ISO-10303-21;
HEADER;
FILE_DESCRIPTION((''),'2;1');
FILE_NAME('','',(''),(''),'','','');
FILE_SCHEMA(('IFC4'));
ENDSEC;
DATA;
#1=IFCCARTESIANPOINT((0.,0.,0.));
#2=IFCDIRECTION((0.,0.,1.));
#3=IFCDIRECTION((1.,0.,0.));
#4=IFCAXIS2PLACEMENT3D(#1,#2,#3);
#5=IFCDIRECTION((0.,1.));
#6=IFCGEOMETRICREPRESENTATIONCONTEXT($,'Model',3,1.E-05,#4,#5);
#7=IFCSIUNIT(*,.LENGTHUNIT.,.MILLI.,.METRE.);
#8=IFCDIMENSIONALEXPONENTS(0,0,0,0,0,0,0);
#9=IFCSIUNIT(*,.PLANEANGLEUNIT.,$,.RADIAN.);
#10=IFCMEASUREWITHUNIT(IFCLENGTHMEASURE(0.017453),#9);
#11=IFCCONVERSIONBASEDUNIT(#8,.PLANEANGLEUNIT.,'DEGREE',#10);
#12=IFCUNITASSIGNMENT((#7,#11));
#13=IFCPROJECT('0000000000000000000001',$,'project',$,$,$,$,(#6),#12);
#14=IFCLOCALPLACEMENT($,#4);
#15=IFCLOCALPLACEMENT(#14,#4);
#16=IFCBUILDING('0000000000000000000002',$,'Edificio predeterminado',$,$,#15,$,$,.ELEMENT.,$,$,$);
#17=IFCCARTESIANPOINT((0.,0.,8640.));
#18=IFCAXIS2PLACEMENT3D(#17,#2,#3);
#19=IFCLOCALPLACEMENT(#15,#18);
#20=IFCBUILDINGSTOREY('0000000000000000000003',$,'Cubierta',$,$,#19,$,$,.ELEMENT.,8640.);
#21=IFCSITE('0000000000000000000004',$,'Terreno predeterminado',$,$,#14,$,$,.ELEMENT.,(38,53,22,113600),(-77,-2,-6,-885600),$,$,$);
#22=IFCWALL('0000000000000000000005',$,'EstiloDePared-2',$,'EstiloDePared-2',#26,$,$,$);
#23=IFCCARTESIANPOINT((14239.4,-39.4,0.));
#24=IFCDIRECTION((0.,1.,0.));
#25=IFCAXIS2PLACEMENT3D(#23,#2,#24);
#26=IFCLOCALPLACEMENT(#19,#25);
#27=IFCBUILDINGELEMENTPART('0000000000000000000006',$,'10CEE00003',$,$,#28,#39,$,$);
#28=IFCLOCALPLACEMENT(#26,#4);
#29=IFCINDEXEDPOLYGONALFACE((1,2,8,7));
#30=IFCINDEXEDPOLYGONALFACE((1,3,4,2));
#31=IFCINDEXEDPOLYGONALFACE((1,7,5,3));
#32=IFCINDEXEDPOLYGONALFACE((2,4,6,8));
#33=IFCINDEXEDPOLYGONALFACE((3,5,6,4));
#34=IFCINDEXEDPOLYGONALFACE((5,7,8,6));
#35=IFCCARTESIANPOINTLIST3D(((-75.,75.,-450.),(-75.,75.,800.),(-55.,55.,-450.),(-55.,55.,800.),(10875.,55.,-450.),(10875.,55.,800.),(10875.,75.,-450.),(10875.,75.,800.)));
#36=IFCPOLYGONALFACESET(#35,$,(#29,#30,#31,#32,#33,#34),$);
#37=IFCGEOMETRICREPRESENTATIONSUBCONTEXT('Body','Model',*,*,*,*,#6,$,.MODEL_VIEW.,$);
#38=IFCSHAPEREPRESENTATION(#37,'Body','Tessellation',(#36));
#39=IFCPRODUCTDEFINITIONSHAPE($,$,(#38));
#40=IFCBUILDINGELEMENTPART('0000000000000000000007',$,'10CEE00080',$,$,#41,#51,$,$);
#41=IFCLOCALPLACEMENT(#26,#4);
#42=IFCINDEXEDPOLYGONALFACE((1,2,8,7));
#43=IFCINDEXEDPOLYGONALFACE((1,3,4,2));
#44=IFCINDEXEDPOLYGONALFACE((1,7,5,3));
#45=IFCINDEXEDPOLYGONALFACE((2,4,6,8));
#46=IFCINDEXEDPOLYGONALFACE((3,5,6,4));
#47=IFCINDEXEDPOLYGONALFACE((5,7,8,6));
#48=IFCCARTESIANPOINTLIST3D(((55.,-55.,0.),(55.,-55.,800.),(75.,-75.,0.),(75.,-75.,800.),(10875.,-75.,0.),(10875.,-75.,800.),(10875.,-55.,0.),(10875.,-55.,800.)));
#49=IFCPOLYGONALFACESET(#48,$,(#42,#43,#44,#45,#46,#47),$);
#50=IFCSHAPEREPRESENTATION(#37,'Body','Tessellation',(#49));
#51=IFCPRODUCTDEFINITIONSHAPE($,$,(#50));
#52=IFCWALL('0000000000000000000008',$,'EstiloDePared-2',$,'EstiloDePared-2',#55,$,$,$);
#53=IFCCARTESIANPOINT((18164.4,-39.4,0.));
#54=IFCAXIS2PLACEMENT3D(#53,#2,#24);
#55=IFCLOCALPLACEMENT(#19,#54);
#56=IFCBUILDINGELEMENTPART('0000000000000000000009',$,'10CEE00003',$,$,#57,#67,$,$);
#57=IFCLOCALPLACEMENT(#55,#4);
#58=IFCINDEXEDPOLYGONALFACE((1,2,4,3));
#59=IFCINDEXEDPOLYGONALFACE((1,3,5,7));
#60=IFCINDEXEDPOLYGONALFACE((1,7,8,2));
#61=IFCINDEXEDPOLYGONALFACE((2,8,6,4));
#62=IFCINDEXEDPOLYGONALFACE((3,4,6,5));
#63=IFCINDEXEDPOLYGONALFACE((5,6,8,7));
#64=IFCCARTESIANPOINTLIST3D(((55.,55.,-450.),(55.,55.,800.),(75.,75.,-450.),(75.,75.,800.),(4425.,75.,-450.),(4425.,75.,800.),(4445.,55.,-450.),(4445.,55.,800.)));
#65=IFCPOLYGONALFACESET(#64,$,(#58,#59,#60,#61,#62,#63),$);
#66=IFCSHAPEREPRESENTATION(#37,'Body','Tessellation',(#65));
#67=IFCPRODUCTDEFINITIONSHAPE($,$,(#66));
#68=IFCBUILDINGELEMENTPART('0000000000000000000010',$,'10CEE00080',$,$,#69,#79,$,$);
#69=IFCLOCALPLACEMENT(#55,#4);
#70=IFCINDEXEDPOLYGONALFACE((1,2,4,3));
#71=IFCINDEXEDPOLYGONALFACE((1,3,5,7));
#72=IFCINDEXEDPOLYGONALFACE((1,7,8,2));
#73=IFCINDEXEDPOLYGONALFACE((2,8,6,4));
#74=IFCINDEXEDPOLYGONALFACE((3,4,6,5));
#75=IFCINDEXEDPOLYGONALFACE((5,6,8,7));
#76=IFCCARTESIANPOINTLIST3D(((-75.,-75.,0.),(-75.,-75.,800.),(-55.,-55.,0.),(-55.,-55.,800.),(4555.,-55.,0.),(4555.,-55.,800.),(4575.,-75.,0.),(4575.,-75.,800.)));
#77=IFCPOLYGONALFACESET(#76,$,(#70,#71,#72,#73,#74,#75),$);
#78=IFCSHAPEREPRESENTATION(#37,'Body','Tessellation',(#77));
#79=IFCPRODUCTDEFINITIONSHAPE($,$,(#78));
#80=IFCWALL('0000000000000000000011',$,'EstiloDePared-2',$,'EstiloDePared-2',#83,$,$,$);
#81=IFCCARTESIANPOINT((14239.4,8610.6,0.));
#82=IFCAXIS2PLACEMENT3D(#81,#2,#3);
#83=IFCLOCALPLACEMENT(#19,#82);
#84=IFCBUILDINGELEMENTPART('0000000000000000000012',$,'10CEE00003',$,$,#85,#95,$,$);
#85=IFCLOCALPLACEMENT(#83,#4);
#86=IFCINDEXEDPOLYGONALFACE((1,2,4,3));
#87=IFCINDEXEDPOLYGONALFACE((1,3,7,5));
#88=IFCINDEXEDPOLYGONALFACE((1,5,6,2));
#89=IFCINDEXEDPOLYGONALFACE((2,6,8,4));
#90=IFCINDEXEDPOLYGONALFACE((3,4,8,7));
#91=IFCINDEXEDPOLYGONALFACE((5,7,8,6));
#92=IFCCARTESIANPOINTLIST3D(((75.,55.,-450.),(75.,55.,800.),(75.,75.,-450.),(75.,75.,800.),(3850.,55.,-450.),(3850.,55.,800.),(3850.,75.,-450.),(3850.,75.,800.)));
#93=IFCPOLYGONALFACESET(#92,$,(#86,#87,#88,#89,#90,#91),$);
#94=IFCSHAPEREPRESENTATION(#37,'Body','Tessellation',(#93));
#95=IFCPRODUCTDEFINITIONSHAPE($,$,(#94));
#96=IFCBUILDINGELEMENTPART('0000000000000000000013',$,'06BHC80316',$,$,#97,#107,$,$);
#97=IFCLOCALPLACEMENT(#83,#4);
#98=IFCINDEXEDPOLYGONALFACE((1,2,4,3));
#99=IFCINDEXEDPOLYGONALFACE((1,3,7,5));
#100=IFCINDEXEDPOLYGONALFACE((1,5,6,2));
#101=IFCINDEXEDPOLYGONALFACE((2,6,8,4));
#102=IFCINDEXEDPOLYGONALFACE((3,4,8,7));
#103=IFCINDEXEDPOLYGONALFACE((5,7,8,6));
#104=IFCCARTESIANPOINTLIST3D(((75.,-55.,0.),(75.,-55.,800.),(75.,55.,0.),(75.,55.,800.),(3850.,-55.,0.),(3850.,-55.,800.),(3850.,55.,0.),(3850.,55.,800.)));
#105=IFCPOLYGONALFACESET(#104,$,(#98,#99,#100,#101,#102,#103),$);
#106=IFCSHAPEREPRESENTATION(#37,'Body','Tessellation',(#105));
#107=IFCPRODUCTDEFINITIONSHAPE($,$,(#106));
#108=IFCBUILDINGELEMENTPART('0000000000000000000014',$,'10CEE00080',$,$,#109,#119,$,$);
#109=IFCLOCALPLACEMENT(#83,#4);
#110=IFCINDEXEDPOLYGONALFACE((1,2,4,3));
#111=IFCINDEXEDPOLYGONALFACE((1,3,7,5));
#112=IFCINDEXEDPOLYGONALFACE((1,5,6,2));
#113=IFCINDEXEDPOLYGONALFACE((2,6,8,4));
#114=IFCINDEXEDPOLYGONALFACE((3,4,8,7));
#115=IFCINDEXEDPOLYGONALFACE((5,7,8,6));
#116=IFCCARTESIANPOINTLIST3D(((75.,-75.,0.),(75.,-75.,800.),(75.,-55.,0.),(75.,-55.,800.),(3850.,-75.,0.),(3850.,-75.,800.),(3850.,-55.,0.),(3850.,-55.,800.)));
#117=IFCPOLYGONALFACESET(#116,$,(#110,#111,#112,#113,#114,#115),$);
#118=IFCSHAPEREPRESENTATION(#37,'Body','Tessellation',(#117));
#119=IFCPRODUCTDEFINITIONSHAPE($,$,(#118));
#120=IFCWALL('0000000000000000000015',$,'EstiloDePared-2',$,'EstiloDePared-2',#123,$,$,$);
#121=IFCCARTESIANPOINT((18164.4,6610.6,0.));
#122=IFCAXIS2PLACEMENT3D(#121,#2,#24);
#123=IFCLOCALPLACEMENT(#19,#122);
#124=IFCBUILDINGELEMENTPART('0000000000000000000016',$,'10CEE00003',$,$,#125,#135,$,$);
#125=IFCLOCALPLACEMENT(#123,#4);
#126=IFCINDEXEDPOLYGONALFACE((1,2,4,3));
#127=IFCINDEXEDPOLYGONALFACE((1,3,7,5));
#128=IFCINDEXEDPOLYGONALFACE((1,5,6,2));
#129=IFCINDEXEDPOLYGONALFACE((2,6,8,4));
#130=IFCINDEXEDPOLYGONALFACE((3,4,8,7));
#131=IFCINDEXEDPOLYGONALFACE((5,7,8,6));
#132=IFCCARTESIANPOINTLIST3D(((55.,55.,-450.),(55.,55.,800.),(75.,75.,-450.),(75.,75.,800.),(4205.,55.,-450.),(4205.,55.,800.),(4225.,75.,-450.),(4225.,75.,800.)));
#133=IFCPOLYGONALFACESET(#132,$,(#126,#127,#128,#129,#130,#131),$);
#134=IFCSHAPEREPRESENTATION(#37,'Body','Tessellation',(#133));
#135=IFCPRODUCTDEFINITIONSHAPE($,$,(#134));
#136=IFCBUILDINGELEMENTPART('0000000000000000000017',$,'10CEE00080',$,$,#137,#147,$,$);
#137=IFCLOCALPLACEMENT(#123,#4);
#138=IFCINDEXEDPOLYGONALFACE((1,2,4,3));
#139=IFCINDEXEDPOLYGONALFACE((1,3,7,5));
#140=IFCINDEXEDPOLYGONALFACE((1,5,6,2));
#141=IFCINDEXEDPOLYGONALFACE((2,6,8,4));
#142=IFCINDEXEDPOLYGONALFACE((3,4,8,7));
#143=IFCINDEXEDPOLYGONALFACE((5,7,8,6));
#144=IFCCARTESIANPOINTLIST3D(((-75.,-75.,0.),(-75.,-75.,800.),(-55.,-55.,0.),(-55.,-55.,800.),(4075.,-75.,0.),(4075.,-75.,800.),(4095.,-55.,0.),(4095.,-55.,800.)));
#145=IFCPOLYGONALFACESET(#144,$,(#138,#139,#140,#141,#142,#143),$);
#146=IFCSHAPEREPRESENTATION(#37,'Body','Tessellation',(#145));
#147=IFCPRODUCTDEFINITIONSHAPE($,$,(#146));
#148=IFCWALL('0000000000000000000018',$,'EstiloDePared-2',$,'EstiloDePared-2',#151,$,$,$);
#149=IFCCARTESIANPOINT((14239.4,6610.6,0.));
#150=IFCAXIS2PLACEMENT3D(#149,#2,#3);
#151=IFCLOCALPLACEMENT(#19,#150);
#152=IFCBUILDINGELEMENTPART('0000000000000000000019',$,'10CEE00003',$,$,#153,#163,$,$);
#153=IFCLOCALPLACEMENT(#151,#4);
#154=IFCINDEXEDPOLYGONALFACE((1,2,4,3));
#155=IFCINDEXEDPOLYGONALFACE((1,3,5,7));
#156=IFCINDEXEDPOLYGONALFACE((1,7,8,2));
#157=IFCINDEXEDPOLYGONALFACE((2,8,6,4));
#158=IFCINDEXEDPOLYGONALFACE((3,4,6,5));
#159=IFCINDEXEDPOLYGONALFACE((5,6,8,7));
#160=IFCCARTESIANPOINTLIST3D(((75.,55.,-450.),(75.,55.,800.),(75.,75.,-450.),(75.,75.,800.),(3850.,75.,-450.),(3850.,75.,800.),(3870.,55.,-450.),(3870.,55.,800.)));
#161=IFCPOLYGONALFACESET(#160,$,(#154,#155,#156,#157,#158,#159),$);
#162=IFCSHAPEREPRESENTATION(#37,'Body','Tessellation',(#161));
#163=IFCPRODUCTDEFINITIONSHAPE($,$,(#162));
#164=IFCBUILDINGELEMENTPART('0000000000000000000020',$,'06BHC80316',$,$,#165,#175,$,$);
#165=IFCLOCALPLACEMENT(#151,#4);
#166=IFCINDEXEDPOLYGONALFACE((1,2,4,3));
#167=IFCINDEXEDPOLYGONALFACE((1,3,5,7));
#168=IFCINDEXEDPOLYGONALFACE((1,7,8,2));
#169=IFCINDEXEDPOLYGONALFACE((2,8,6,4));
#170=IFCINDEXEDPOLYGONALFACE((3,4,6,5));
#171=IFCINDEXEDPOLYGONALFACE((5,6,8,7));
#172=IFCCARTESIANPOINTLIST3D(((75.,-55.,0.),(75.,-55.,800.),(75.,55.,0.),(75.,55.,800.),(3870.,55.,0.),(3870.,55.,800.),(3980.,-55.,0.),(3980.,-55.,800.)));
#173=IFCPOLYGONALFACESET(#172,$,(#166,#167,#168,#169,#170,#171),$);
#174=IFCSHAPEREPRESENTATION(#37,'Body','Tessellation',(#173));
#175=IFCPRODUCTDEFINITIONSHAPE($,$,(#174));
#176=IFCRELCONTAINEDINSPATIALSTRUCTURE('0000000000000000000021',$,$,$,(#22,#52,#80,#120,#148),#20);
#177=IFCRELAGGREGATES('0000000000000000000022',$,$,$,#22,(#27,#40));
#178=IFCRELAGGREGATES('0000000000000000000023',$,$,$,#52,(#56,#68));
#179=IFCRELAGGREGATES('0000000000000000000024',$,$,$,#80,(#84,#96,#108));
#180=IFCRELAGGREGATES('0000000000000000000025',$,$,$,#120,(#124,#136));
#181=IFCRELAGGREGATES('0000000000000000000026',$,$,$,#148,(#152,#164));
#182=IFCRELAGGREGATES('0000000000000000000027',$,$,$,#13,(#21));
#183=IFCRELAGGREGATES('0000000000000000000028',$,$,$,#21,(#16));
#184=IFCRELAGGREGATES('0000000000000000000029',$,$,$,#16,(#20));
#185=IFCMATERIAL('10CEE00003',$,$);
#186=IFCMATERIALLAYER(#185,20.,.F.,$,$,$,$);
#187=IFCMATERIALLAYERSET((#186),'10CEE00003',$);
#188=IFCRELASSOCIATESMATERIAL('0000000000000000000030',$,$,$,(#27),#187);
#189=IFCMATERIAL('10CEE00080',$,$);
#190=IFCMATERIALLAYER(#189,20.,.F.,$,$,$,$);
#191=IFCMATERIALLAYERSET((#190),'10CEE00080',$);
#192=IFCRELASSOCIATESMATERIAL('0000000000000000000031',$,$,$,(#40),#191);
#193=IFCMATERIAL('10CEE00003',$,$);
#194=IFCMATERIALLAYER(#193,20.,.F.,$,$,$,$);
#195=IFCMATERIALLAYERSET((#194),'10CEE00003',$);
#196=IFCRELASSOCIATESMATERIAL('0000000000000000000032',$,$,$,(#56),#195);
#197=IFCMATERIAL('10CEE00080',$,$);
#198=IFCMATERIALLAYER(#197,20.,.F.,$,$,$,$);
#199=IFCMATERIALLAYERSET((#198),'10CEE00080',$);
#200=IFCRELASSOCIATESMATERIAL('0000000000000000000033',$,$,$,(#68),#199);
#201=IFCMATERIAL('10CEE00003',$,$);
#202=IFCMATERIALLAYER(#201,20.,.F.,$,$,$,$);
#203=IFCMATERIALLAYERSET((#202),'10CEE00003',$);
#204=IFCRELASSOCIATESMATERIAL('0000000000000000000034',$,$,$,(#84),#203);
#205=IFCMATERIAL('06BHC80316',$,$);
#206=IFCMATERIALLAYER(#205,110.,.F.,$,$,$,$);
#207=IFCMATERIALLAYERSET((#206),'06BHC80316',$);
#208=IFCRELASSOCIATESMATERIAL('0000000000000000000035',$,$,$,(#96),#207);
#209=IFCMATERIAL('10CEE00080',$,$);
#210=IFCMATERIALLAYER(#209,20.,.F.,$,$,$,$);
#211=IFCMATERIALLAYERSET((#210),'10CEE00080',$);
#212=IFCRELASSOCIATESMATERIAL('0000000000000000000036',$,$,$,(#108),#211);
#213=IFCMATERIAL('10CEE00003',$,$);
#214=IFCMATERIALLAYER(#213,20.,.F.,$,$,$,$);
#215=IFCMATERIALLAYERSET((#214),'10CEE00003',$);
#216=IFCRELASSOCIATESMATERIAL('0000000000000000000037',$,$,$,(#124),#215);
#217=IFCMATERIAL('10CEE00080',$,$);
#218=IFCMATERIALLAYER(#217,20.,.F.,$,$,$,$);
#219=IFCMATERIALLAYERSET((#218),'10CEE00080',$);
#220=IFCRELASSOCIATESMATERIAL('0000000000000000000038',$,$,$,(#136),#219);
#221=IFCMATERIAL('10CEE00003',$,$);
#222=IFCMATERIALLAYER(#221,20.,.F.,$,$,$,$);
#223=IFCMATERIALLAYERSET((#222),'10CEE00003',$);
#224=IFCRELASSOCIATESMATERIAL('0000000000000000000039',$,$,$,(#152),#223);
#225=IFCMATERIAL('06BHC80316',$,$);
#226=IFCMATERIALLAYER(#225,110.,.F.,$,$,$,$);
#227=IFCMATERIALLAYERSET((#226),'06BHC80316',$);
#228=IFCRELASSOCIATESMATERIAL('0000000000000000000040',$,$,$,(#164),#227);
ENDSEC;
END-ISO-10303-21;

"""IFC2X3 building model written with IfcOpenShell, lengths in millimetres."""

from ifc_helpers import new_model, entity, si_unit, converted_unit, direction, frame, origin_with_axes, place, context, subcontext, project, spatial, polyline, outline, extrude, material, layer, layer_set, layer_usage, element, aggregate, save


model = new_model("IFC2X3")

# Units and contexts
model_context = context("Model", 3, precision=1e-05, world=origin_with_axes(), true_north=direction((0.0, 1.0)))
body_context = subcontext(model_context, "Body", "Model", "MODEL_VIEW")
ifc_project = project(units=[si_unit("LENGTHUNIT", "METRE", prefix="MILLI"), converted_unit("PLANEANGLEUNIT", "DEGREE", entity("IfcLengthMeasure", 0.017453), si_unit("PLANEANGLEUNIT", "RADIAN"), dimensions=[0, 0, 0, 0, 0, 0, 0])], contexts=[model_context])

# Site, building, storey
site_placement = place(None, origin_with_axes())
site = spatial("IfcSite", under=ifc_project, at=site_placement, Name="Terreno predeterminado", CompositionType="ELEMENT", RefLatitude=(38, 53, 22, 113600), RefLongitude=(-77, -2, -6, -885600))
building_placement = place(site_placement, origin_with_axes())
building = spatial("IfcBuilding", under=site, at=building_placement, Name="Edificio predeterminado", CompositionType="ELEMENT")
storey_placement = place(building_placement, frame((0.0, 0.0, 8640.0), z_axis=(0.0, 0.0, 1.0), x_axis=(1.0, 0.0, 0.0)))
storey = spatial("IfcBuildingStorey", under=building, at=storey_placement, Name="Cubierta", CompositionType="ELEMENT", Elevation=8640.0)

# Walls, building element parts
wall_1_placement = place(storey_placement, frame((14239.4, -39.4, 0.0), z_axis=(0.0, 0.0, 1.0), x_axis=(0.0, 1.0, 0.0)))
wall_1 = element("IfcWall", 1, at=wall_1_placement, inside=storey, Name="EstiloDePared-2", ObjectType="EstiloDePared-2")
ifc_material_1 = material(Name="10CEE00003")
ifc_layer_1 = layer(ifc_material_1, 20.0, ventilated=False)
ifc_layer_set_1 = layer_set([ifc_layer_1], Name="10CEE00003")
ifc_layer_usage_1 = layer_usage(ifc_layer_set_1, "AXIS2", "NEGATIVE", -75.0)
building_element_part_1_placement = place(wall_1_placement, origin_with_axes())
building_element_part_1 = element("IfcBuildingElementPart", 2, at=building_element_part_1_placement, material=ifc_layer_usage_1, Name="10CEE00003", context=body_context, shape_type="SweptSolid", body=[
    extrude(outline(polyline([(10875.0, 75.0), (10875.0, 55.0), (-55.0, 55.0), (-75.0, 75.0), (10875.0, 75.0)])), frame((0.0, 0.0, -450.0), z_axis=(0.0, 0.0, 1.0), x_axis=(1.0, 0.0, 0.0)), (0.0, 0.0, 1.0), 1250.0),
])
ifc_material_2 = material(Name="10CEE00080")
ifc_layer_2 = layer(ifc_material_2, 20.0, ventilated=False)
ifc_layer_set_2 = layer_set([ifc_layer_2], Name="10CEE00080")
ifc_layer_usage_2 = layer_usage(ifc_layer_set_2, "AXIS2", "NEGATIVE", 55.0)
building_element_part_2_placement = place(wall_1_placement, origin_with_axes())
building_element_part_2 = element("IfcBuildingElementPart", 3, at=building_element_part_2_placement, material=ifc_layer_usage_2, Name="10CEE00080", context=body_context, shape_type="SweptSolid", body=[
    extrude(outline(polyline([(10875.0, -55.0), (10875.0, -75.0), (75.0, -75.0), (55.0, -55.0), (10875.0, -55.0)])), origin_with_axes(), (0.0, 0.0, 1.0), 800.0),
])
aggregate(wall_1, [building_element_part_1, building_element_part_2])
wall_2_placement = place(storey_placement, frame((18164.4, -39.4, 0.0), z_axis=(0.0, 0.0, 1.0), x_axis=(0.0, 1.0, 0.0)))
wall_2 = element("IfcWall", 4, at=wall_2_placement, inside=storey, Name="EstiloDePared-2", ObjectType="EstiloDePared-2")
ifc_material_3 = material(Name="10CEE00003")
ifc_layer_3 = layer(ifc_material_3, 20.0, ventilated=False)
ifc_layer_set_3 = layer_set([ifc_layer_3], Name="10CEE00003")
ifc_layer_usage_3 = layer_usage(ifc_layer_set_3, "AXIS2", "NEGATIVE", -75.0)
building_element_part_3_placement = place(wall_2_placement, origin_with_axes())
building_element_part_3 = element("IfcBuildingElementPart", 5, at=building_element_part_3_placement, material=ifc_layer_usage_3, Name="10CEE00003", context=body_context, shape_type="SweptSolid", body=[
    extrude(outline(polyline([(4425.0, 75.0), (4445.0, 55.0), (55.0, 55.0), (75.0, 75.0), (4425.0, 75.0)])), frame((0.0, 0.0, -450.0), z_axis=(0.0, 0.0, 1.0), x_axis=(1.0, 0.0, 0.0)), (0.0, 0.0, 1.0), 1250.0),
])
ifc_material_4 = material(Name="10CEE00080")
ifc_layer_4 = layer(ifc_material_4, 20.0, ventilated=False)
ifc_layer_set_4 = layer_set([ifc_layer_4], Name="10CEE00080")
ifc_layer_usage_4 = layer_usage(ifc_layer_set_4, "AXIS2", "NEGATIVE", 55.0)
building_element_part_4_placement = place(wall_2_placement, origin_with_axes())
building_element_part_4 = element("IfcBuildingElementPart", 6, at=building_element_part_4_placement, material=ifc_layer_usage_4, Name="10CEE00080", context=body_context, shape_type="SweptSolid", body=[
    extrude(outline(polyline([(4555.0, -55.0), (4575.0, -75.0), (-75.0, -75.0), (-55.0, -55.0), (4555.0, -55.0)])), origin_with_axes(), (0.0, 0.0, 1.0), 800.0),
])
aggregate(wall_2, [building_element_part_3, building_element_part_4])
wall_3_placement = place(storey_placement, frame((14239.4, 8610.6, 0.0), z_axis=(0.0, 0.0, 1.0), x_axis=(1.0, 0.0, 0.0)))
wall_3 = element("IfcWall", 7, at=wall_3_placement, inside=storey, Name="EstiloDePared-2", ObjectType="EstiloDePared-2")
ifc_material_5 = material(Name="10CEE00003")
ifc_layer_5 = layer(ifc_material_5, 20.0, ventilated=False)
ifc_layer_set_5 = layer_set([ifc_layer_5], Name="10CEE00003")
ifc_layer_usage_5 = layer_usage(ifc_layer_set_5, "AXIS2", "NEGATIVE", -75.0)
building_element_part_5_placement = place(wall_3_placement, origin_with_axes())
building_element_part_5 = element("IfcBuildingElementPart", 8, at=building_element_part_5_placement, material=ifc_layer_usage_5, Name="10CEE00003", context=body_context, shape_type="SweptSolid", body=[
    extrude(outline(polyline([(3850.0, 75.0), (3850.0, 55.0), (75.0, 55.0), (75.0, 75.0), (3850.0, 75.0)])), frame((0.0, 0.0, -450.0), z_axis=(0.0, 0.0, 1.0), x_axis=(1.0, 0.0, 0.0)), (0.0, 0.0, 1.0), 1250.0),
])
ifc_material_6 = material(Name="06BHC80316")
ifc_layer_6 = layer(ifc_material_6, 110.0, ventilated=False)
ifc_layer_set_6 = layer_set([ifc_layer_6], Name="06BHC80316")
ifc_layer_usage_6 = layer_usage(ifc_layer_set_6, "AXIS2", "NEGATIVE", -55.0)
building_element_part_6_placement = place(wall_3_placement, origin_with_axes())
building_element_part_6 = element("IfcBuildingElementPart", 9, at=building_element_part_6_placement, material=ifc_layer_usage_6, Name="06BHC80316", context=body_context, shape_type="SweptSolid", body=[
    extrude(outline(polyline([(3850.0, 55.0), (3850.0, -55.0), (75.0, -55.0), (75.0, 55.0), (3850.0, 55.0)])), origin_with_axes(), (0.0, 0.0, 1.0), 800.0),
])
ifc_material_7 = material(Name="10CEE00080")
ifc_layer_7 = layer(ifc_material_7, 20.0, ventilated=False)
ifc_layer_set_7 = layer_set([ifc_layer_7], Name="10CEE00080")
ifc_layer_usage_7 = layer_usage(ifc_layer_set_7, "AXIS2", "NEGATIVE", 55.0)
building_element_part_7_placement = place(wall_3_placement, origin_with_axes())
building_element_part_7 = element("IfcBuildingElementPart", 10, at=building_element_part_7_placement, material=ifc_layer_usage_7, Name="10CEE00080", context=body_context, shape_type="SweptSolid", body=[
    extrude(outline(polyline([(3850.0, -55.0), (3850.0, -75.0), (75.0, -75.0), (75.0, -55.0), (3850.0, -55.0)])), origin_with_axes(), (0.0, 0.0, 1.0), 800.0),
])
aggregate(wall_3, [building_element_part_5, building_element_part_6, building_element_part_7])
wall_4_placement = place(storey_placement, frame((18164.4, 6610.6, 0.0), z_axis=(0.0, 0.0, 1.0), x_axis=(0.0, 1.0, 0.0)))
wall_4 = element("IfcWall", 11, at=wall_4_placement, inside=storey, Name="EstiloDePared-2", ObjectType="EstiloDePared-2")
ifc_material_8 = material(Name="10CEE00003")
ifc_layer_8 = layer(ifc_material_8, 20.0, ventilated=False)
ifc_layer_set_8 = layer_set([ifc_layer_8], Name="10CEE00003")
ifc_layer_usage_8 = layer_usage(ifc_layer_set_8, "AXIS2", "NEGATIVE", -75.0)
building_element_part_8_placement = place(wall_4_placement, origin_with_axes())
building_element_part_8 = element("IfcBuildingElementPart", 12, at=building_element_part_8_placement, material=ifc_layer_usage_8, Name="10CEE00003", context=body_context, shape_type="SweptSolid", body=[
    extrude(outline(polyline([(4225.0, 75.0), (4205.0, 55.0), (55.0, 55.0), (75.0, 75.0), (4225.0, 75.0)])), frame((0.0, 0.0, -450.0), z_axis=(0.0, 0.0, 1.0), x_axis=(1.0, 0.0, 0.0)), (0.0, 0.0, 1.0), 1250.0),
])
ifc_material_9 = material(Name="10CEE00080")
ifc_layer_9 = layer(ifc_material_9, 20.0, ventilated=False)
ifc_layer_set_9 = layer_set([ifc_layer_9], Name="10CEE00080")
ifc_layer_usage_9 = layer_usage(ifc_layer_set_9, "AXIS2", "NEGATIVE", 55.0)
building_element_part_9_placement = place(wall_4_placement, origin_with_axes())
building_element_part_9 = element("IfcBuildingElementPart", 13, at=building_element_part_9_placement, material=ifc_layer_usage_9, Name="10CEE00080", context=body_context, shape_type="SweptSolid", body=[
    extrude(outline(polyline([(4095.0, -55.0), (4075.0, -75.0), (-75.0, -75.0), (-55.0, -55.0), (4095.0, -55.0)])), origin_with_axes(), (0.0, 0.0, 1.0), 800.0),
])
aggregate(wall_4, [building_element_part_8, building_element_part_9])
wall_5_placement = place(storey_placement, frame((14239.4, 6610.6, 0.0), z_axis=(0.0, 0.0, 1.0), x_axis=(1.0, 0.0, 0.0)))
wall_5 = element("IfcWall", 14, at=wall_5_placement, inside=storey, Name="EstiloDePared-2", ObjectType="EstiloDePared-2")
ifc_material_10 = material(Name="10CEE00003")
ifc_layer_10 = layer(ifc_material_10, 20.0, ventilated=False)
ifc_layer_set_10 = layer_set([ifc_layer_10], Name="10CEE00003")
ifc_layer_usage_10 = layer_usage(ifc_layer_set_10, "AXIS2", "NEGATIVE", -75.0)
building_element_part_10_placement = place(wall_5_placement, origin_with_axes())
building_element_part_10 = element("IfcBuildingElementPart", 15, at=building_element_part_10_placement, material=ifc_layer_usage_10, Name="10CEE00003", context=body_context, shape_type="SweptSolid", body=[
    extrude(outline(polyline([(3850.0, 75.0), (3870.0, 55.0), (75.0, 55.0), (75.0, 75.0), (3850.0, 75.0)])), frame((0.0, 0.0, -450.0), z_axis=(0.0, 0.0, 1.0), x_axis=(1.0, 0.0, 0.0)), (0.0, 0.0, 1.0), 1250.0),
])
ifc_material_11 = material(Name="06BHC80316")
ifc_layer_11 = layer(ifc_material_11, 110.0, ventilated=False)
ifc_layer_set_11 = layer_set([ifc_layer_11], Name="06BHC80316")
ifc_layer_usage_11 = layer_usage(ifc_layer_set_11, "AXIS2", "NEGATIVE", -55.0)
building_element_part_11_placement = place(wall_5_placement, origin_with_axes())
building_element_part_11 = element("IfcBuildingElementPart", 16, at=building_element_part_11_placement, material=ifc_layer_usage_11, Name="06BHC80316", context=body_context, shape_type="SweptSolid", body=[
    extrude(outline(polyline([(3870.0, 55.0), (3980.0, -55.0), (75.0, -55.0), (75.0, 55.0), (3870.0, 55.0)])), origin_with_axes(), (0.0, 0.0, 1.0), 800.0),
])
aggregate(wall_5, [building_element_part_10, building_element_part_11])

save(model, "model.ifc")
